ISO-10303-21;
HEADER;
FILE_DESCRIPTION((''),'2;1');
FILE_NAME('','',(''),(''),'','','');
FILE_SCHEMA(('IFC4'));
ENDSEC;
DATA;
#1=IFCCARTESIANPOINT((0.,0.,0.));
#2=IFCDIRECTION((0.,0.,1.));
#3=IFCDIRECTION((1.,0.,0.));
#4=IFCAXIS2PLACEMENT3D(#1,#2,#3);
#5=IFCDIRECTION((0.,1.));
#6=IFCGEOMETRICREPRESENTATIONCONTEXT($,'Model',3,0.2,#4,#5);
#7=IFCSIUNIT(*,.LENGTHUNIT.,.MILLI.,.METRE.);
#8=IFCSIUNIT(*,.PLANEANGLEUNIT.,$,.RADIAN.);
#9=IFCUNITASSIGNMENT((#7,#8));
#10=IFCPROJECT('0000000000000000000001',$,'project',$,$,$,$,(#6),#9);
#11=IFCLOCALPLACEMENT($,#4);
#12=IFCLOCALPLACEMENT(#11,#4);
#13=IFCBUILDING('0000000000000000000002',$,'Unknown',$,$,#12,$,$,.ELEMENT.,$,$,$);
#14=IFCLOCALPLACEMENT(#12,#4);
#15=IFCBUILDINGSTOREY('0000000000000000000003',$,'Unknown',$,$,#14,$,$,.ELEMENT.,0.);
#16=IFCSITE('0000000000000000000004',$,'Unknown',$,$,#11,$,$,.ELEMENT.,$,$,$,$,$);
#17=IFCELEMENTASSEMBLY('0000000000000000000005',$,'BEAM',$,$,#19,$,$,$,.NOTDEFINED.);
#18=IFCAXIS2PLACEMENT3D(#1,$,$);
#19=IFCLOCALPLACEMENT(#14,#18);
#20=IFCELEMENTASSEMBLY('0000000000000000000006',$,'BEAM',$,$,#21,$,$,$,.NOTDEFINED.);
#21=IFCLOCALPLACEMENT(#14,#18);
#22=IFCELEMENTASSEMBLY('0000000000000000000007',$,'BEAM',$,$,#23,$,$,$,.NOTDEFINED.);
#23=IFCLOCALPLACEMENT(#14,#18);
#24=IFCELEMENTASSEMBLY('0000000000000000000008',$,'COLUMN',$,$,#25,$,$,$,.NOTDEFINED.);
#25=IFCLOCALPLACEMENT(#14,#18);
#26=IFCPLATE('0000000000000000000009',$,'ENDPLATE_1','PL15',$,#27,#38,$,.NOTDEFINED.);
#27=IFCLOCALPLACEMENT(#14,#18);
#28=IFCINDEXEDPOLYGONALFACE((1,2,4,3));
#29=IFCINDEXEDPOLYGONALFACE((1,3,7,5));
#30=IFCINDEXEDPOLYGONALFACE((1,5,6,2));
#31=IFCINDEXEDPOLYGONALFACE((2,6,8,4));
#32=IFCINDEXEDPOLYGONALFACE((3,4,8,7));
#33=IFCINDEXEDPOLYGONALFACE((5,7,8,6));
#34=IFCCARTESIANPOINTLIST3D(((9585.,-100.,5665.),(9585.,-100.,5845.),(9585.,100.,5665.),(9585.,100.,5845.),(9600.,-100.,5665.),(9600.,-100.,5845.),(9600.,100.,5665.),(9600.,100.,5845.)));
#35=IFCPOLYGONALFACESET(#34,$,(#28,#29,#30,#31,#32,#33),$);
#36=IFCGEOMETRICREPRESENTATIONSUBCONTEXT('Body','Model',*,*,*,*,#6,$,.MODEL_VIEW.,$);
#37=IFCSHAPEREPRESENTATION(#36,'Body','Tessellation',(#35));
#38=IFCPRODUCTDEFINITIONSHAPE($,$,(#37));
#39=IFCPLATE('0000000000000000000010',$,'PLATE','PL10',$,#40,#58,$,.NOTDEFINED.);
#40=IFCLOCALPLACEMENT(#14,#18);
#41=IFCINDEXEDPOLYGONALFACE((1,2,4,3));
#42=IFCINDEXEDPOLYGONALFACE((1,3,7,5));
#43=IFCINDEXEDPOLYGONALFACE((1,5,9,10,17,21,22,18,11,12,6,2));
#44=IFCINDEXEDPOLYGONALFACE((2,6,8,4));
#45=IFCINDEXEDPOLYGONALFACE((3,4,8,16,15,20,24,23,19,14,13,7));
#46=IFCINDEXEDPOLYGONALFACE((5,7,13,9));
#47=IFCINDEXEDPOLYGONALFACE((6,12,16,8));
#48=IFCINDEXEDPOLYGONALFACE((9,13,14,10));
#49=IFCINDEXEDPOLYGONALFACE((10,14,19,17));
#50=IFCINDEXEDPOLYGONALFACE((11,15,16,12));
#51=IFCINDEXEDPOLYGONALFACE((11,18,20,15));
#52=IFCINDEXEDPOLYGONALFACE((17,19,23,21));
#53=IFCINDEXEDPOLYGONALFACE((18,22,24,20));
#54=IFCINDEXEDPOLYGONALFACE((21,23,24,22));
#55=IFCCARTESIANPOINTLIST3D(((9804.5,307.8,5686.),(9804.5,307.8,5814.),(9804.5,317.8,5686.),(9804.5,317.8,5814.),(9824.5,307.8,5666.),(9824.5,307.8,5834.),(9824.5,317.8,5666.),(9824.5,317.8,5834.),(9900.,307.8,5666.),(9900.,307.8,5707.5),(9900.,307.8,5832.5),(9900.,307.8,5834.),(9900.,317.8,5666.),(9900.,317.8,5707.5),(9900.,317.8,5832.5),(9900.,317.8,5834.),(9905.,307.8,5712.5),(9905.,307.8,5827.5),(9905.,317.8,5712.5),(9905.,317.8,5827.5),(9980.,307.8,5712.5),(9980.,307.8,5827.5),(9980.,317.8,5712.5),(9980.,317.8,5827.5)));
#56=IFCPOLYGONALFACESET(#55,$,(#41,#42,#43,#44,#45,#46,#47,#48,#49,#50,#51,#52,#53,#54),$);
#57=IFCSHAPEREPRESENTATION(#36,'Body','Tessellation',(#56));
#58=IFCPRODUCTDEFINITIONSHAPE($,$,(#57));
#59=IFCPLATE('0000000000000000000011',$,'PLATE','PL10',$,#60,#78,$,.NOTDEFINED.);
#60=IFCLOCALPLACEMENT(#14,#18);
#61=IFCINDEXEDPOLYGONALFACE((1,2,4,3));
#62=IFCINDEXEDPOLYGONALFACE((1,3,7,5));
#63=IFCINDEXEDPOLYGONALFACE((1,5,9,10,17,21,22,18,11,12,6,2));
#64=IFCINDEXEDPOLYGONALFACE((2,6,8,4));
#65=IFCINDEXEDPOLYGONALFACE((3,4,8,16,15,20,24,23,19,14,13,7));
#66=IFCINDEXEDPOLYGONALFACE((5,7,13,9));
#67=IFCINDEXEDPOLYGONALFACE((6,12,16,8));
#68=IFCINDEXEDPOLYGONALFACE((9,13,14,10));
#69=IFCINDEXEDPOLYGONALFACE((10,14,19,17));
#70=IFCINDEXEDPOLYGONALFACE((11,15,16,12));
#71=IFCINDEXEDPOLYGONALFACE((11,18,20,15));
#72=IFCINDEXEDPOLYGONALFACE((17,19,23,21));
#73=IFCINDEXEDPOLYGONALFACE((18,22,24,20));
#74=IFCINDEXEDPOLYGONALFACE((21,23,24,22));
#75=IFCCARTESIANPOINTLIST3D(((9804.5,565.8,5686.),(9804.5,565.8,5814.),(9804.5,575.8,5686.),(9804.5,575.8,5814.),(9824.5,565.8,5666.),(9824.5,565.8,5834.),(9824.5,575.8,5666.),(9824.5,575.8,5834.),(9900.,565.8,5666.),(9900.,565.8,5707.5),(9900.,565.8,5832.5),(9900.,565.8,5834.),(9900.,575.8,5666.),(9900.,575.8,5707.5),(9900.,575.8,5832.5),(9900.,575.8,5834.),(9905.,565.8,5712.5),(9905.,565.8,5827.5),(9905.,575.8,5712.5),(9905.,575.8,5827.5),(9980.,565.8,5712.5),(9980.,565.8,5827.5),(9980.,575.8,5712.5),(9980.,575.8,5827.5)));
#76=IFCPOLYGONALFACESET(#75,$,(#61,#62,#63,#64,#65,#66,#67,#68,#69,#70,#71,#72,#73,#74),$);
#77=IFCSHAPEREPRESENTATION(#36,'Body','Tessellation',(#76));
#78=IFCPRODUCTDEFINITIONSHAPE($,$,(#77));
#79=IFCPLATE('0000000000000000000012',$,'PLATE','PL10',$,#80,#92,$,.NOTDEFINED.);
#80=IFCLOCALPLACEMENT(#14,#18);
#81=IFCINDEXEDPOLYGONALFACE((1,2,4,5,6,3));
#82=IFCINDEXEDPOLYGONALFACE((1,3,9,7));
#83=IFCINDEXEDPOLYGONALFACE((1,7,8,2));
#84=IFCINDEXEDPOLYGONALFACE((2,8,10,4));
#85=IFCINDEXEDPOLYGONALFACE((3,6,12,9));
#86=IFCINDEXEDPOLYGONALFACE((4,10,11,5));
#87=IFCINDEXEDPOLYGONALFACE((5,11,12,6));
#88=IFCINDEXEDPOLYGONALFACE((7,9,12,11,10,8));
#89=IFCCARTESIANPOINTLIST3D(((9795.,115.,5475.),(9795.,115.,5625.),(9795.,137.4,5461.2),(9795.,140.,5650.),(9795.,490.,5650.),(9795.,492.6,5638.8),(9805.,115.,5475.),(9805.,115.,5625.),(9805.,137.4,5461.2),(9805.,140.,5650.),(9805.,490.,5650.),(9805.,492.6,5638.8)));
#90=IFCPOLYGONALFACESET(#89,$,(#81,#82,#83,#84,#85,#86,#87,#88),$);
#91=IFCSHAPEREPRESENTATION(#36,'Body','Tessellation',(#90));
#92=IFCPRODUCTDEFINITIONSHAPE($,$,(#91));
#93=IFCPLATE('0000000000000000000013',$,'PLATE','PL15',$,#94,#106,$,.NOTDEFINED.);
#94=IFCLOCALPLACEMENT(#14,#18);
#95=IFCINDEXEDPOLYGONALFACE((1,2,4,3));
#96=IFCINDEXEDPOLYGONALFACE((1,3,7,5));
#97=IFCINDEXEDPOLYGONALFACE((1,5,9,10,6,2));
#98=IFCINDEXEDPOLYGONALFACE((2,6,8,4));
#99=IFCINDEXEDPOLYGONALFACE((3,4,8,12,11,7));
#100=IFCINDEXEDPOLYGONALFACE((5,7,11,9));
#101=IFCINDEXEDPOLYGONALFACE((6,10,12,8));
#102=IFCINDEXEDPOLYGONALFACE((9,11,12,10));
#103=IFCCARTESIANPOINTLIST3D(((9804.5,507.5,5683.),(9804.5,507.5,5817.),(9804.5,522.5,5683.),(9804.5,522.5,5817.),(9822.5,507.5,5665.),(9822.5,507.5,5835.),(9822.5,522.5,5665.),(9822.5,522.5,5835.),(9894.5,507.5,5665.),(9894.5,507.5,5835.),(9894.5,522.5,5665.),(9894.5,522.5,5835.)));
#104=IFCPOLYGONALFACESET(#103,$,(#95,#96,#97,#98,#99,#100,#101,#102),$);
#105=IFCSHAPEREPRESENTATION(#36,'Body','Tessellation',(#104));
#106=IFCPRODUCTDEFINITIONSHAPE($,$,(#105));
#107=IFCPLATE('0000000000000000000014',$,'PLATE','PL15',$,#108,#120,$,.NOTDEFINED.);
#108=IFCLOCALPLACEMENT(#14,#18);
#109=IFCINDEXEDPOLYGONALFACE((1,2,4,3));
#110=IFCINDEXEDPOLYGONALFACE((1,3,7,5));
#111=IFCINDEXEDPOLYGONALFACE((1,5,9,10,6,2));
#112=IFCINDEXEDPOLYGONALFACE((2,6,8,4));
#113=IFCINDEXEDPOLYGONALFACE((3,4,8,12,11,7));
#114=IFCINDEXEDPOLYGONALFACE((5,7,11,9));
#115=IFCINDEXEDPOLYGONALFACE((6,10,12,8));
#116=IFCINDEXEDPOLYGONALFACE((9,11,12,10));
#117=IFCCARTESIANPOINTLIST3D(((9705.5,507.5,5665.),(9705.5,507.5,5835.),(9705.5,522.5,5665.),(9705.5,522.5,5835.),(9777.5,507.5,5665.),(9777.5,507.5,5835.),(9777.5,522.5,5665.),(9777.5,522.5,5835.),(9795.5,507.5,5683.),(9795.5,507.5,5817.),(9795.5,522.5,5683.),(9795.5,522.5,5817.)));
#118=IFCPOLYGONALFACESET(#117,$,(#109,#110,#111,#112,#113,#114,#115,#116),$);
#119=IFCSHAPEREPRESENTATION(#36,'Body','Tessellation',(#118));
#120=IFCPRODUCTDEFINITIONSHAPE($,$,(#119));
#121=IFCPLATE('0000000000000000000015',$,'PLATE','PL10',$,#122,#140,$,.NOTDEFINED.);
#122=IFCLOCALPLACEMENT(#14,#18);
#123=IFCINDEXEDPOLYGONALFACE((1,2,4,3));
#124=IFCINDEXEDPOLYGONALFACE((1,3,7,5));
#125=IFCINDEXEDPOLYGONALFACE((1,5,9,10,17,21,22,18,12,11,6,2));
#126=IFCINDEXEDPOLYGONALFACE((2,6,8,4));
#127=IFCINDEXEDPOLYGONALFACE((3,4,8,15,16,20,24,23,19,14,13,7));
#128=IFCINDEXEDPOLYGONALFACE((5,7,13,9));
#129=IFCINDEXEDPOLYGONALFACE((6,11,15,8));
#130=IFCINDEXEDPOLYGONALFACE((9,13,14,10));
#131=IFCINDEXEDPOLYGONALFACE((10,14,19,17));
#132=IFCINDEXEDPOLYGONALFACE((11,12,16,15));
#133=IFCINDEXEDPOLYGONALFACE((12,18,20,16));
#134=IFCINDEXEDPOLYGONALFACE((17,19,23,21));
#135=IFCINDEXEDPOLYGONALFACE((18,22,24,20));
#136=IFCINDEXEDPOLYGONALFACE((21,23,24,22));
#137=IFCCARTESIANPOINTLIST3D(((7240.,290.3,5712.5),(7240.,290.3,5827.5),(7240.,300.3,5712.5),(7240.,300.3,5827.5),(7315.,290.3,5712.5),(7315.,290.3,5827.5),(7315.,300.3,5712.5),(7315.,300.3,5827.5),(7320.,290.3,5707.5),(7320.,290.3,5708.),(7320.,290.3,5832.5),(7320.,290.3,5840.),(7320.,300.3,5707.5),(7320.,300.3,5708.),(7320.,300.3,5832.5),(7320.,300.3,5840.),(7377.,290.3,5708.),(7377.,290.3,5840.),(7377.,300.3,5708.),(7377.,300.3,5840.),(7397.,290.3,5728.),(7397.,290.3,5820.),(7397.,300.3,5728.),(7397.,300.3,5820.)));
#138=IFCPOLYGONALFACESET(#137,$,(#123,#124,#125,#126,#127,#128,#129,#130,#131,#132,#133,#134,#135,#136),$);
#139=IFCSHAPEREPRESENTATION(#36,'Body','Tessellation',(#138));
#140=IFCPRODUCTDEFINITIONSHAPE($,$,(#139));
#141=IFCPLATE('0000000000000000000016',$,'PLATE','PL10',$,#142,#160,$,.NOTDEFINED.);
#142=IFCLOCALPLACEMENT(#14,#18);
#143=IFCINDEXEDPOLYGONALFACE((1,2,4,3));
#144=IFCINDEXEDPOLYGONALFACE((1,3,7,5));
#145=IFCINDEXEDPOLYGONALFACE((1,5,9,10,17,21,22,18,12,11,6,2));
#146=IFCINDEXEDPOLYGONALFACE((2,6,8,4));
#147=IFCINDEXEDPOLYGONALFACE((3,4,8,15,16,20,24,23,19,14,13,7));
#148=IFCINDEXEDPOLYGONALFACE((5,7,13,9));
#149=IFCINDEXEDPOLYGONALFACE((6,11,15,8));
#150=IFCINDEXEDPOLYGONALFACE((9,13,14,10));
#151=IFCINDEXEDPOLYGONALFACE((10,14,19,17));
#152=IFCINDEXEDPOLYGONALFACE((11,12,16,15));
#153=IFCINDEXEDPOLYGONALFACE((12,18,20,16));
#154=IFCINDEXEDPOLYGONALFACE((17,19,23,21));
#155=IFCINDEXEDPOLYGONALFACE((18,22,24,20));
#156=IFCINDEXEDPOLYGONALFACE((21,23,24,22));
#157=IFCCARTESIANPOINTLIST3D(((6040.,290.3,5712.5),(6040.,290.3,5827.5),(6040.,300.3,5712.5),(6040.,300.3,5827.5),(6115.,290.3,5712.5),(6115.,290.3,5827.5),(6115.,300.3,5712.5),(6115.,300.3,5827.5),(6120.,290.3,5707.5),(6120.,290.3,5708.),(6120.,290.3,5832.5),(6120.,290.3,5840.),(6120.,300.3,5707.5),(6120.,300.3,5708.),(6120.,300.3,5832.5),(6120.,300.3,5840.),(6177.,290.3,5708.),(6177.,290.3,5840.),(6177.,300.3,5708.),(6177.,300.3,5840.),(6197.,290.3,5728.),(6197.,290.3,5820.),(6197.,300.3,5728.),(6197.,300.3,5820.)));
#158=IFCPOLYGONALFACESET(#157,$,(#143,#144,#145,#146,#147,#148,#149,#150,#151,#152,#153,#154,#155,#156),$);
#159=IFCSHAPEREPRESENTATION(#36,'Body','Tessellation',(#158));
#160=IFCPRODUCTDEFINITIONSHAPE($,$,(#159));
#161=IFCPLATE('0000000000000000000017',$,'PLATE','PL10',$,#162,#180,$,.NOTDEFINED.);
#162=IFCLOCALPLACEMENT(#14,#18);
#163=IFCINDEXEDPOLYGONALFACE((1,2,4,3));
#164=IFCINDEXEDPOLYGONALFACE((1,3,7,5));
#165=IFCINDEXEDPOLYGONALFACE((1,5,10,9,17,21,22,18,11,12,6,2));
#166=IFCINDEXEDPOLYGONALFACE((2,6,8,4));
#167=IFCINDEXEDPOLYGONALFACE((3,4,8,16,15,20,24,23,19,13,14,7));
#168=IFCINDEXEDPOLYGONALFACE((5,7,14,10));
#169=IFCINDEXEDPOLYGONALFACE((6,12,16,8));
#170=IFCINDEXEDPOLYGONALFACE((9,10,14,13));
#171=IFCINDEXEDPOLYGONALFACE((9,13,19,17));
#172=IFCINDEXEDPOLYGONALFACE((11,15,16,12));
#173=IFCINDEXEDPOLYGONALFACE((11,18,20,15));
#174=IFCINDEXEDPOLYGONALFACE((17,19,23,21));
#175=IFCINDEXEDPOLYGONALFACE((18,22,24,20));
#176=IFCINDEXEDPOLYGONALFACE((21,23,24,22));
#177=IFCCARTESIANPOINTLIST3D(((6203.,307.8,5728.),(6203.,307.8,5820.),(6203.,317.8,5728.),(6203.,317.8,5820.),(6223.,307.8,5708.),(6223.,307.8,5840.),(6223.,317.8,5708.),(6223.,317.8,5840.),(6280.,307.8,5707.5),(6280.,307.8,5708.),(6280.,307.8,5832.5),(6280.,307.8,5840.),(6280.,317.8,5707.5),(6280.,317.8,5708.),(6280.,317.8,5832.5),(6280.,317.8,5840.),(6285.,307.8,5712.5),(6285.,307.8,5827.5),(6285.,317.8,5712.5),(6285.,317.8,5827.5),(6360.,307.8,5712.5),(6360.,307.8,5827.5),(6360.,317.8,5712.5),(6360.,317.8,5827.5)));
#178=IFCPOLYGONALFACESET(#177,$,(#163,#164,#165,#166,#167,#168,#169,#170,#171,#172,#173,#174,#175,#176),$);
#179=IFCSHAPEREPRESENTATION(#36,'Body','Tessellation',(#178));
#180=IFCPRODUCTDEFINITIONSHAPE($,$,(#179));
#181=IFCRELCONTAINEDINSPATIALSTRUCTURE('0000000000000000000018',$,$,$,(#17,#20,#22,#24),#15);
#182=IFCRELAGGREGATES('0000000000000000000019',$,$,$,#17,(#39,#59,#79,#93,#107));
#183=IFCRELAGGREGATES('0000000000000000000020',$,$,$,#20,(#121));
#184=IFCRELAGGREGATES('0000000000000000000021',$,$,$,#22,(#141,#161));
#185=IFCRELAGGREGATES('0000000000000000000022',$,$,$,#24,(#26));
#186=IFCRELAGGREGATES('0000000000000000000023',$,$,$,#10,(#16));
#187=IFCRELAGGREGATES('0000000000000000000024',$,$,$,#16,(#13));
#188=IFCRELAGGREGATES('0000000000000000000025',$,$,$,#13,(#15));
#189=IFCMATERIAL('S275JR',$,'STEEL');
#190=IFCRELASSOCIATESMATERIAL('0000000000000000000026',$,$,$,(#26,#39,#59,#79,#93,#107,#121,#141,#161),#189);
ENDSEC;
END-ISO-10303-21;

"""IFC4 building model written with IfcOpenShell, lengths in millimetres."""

from ifc_helpers import new_model, si_unit, direction, frame, origin_with_axes, place, context, subcontext, project, spatial, line, indexed_curve, outline, extrude, material, element, aggregate, save


model = new_model("IFC4")

# Units and contexts
model_context = context("Model", 3, precision=0.2, world=origin_with_axes(), true_north=direction((0.0, 1.0)))
body_context = subcontext(model_context, "Body", "Model", "MODEL_VIEW")
ifc_project = project(units=[si_unit("LENGTHUNIT", "METRE", prefix="MILLI"), si_unit("PLANEANGLEUNIT", "RADIAN")], contexts=[model_context])

# Site, building, storey
site_placement = place(None, origin_with_axes())
site = spatial("IfcSite", under=ifc_project, at=site_placement, Name="Unknown", CompositionType="ELEMENT")
building_placement = place(site_placement, origin_with_axes())
building = spatial("IfcBuilding", under=site, at=building_placement, Name="Unknown", CompositionType="ELEMENT")
storey_placement = place(building_placement, origin_with_axes())
storey = spatial("IfcBuildingStorey", under=building, at=storey_placement, Name="Unknown", CompositionType="ELEMENT", Elevation=0.0)

# Shared definitions
ifc_material_1 = material(Name="S275JR", Category="STEEL")

# Element assemblies
assembly_1_placement = place(storey_placement, frame((9800.0, 0.0, 5750.0), z_axis=(1.0, 0.0, 0.0), x_axis=(0.0, 1.0, 0.0)))
assembly_1 = element("IfcElementAssembly", 1, at=assembly_1_placement, inside=storey, Name="BEAM", PredefinedType="NOTDEFINED")
assembly_2_placement = place(storey_placement, frame((7400.0, 3600.0, 5774.0), z_axis=(-1.0, 0.0, 0.0), x_axis=(-0.000002, -1.0, 0.0)))
assembly_2 = element("IfcElementAssembly", 2, at=assembly_2_placement, inside=storey, Name="BEAM", PredefinedType="NOTDEFINED")
assembly_3_placement = place(storey_placement, frame((6200.0, 3600.0, 5774.0), z_axis=(-1.0, 0.0, 0.0), x_axis=(-0.000002, -1.0, 0.0)))
assembly_3 = element("IfcElementAssembly", 3, at=assembly_3_placement, inside=storey, Name="BEAM", PredefinedType="NOTDEFINED")

# Element assembly, plate
assembly_4_placement = place(storey_placement, frame((9800.0, 0.0, 200.0), z_axis=(-1.0, 0.0, 0.0), x_axis=(0.0, 0.0, 1.0)))
assembly_4 = element("IfcElementAssembly", 4, at=assembly_4_placement, inside=storey, Name="COLUMN", PredefinedType="NOTDEFINED")
plate_1_placement = place(assembly_4_placement, frame((5465.0, -100.0, 207.5), z_axis=(0.0, 0.0, 1.0), x_axis=(1.0, 0.0, 0.0)))
plate_1 = element("IfcPlate", 5, at=plate_1_placement, material=ifc_material_1, Name="ENDPLATE_1", Description="PL15", PredefinedType="NOTDEFINED", context=body_context, shape_type="SolidModel", body=[
    extrude(outline(indexed_curve([(0.0, 0.0), (180.0, 0.0), (180.0, 200.0), (0.0, 200.0)], segments=[line(1, 2, 3, 4, 1)])), frame((0.0, 0.0, 7.5), z_axis=(0.0, 0.0, 1.0), x_axis=(1.0, 0.0, 0.0)), (0.0, -0.000002, -1.0), 15.0),
])

# Plates
plate_2_placement = place(assembly_1_placement, frame((312.8, -64.0, 4.5), z_axis=(-1.0, 0.0, 0.0), x_axis=(0.0, -0.707107, 0.707107)))
plate_2 = element("IfcPlate", 6, at=plate_2_placement, material=ifc_material_1, Name="PLATE", Description="PL10", PredefinedType="NOTDEFINED", context=body_context, shape_type="SolidModel", body=[
    extrude(outline(indexed_curve([(0.0, 0.0), (28.3, 0.0), (81.7, 53.4), (52.3, 82.7), (52.3, 89.8), (105.4, 142.8), (24.0, 224.2), (-29.0, 171.1), (-36.1, 171.1), (-37.1, 172.2), (-90.5, 118.8), (-90.5, 90.5)], segments=[line(1, 2, 3, 4, 5, 6, 7, 8, 9, 10, 11, 12, 1)])), frame((0.0, 0.0, 5.0), z_axis=(0.0, 0.0, 1.0), x_axis=(1.0, 0.0, 0.0)), (0.0, -0.000002, -1.0), 10.0),
])
plate_3_placement = place(assembly_1_placement, frame((570.8, -64.0, 4.5), z_axis=(-1.0, 0.0, 0.0), x_axis=(0.0, -0.707107, 0.707107)))
plate_3 = element("IfcPlate", 7, at=plate_3_placement, material=ifc_material_1, Name="PLATE", Description="PL10", PredefinedType="NOTDEFINED", context=body_context, shape_type="SolidModel", body=[
    extrude(outline(indexed_curve([(0.0, 0.0), (28.3, 0.0), (81.7, 53.4), (52.3, 82.7), (52.3, 89.8), (105.4, 142.8), (24.0, 224.2), (-29.0, 171.1), (-36.1, 171.1), (-37.1, 172.2), (-90.5, 118.8), (-90.5, 90.5)], segments=[line(1, 2, 3, 4, 5, 6, 7, 8, 9, 10, 11, 12, 1)])), frame((0.0, 0.0, 5.0), z_axis=(0.0, 0.0, 1.0), x_axis=(1.0, 0.0, 0.0)), (0.0, -0.000002, -1.0), 10.0),
])
plate_4_placement = place(assembly_1_placement, frame((115.0, -300.0, 0.0), z_axis=(0.0, -0.000002, -1.0), x_axis=(0.0, 1.0, 0.0)))
plate_4 = element("IfcPlate", 8, at=plate_4_placement, material=ifc_material_1, Name="PLATE", Description="PL10", PredefinedType="NOTDEFINED", context=body_context, shape_type="SolidModel", body=[
    extrude(outline(indexed_curve([(11.2, 22.4), (25.0, 0.0), (175.0, 0.0), (200.0, 25.0), (200.0, 375.0), (188.8, 377.6)], segments=[line(1, 2, 3, 4, 5, 6, 1)])), frame((0.0, 0.0, 5.0), z_axis=(0.0, 0.0, 1.0), x_axis=(1.0, 0.0, 0.0)), (0.0, -0.000002, -1.0), 10.0),
])
plate_5_placement = place(assembly_1_placement, frame((515.0, -85.0, 4.5), z_axis=(-1.0, 0.0, 0.0), x_axis=(0.0, 0.0, 1.0)))
plate_5 = element("IfcPlate", 9, at=plate_5_placement, material=ifc_material_1, Name="PLATE", Description="PL15", PredefinedType="NOTDEFINED", context=body_context, shape_type="SolidModel", body=[
    extrude(outline(indexed_curve([(0.0, 18.0), (18.0, 0.0), (90.0, 0.0), (90.0, 170.0), (18.0, 170.0), (0.0, 152.0)], segments=[line(1, 2, 3, 4, 5, 6, 1)])), frame((0.0, 0.0, 7.5), z_axis=(0.0, 0.0, 1.0), x_axis=(1.0, 0.0, 0.0)), (0.0, -0.000002, -1.0), 15.0),
])
plate_6_placement = place(assembly_1_placement, frame((515.0, -85.0, -4.5), z_axis=(1.0, 0.0, 0.0), x_axis=(0.0, -0.000002, -1.0)))
plate_6 = element("IfcPlate", 10, at=plate_6_placement, material=ifc_material_1, Name="PLATE", Description="PL15", PredefinedType="NOTDEFINED", context=body_context, shape_type="SolidModel", body=[
    extrude(outline(indexed_curve([(0.0, 18.0), (18.0, 0.0), (90.0, 0.0), (90.0, 170.0), (18.0, 170.0), (0.0, 152.0)], segments=[line(1, 2, 3, 4, 5, 6, 1)])), frame((0.0, 0.0, 7.5), z_axis=(0.0, 0.0, 1.0), x_axis=(1.0, 0.0, 0.0)), (0.0, -0.000002, -1.0), 15.0),
])
aggregate(assembly_1, [plate_2, plate_3, plate_4, plate_5, plate_6])
plate_7_placement = place(assembly_2_placement, frame((3304.7, -46.0, 3.0), z_axis=(-1.0, 0.0, 0.0), x_axis=(0.0, -0.707107, 0.707107)))
plate_7 = element("IfcPlate", 11, at=plate_7_placement, material=ifc_material_1, Name="PLATE", Description="PL10", PredefinedType="NOTDEFINED", context=body_context, shape_type="SolidModel", body=[
    extrude(outline(indexed_curve([(0.0, 0.0), (28.3, 0.0), (68.6, 40.3), (68.9, 40.0), (68.9, 47.0), (122.0, 100.1), (40.7, 181.4), (-12.4, 128.3), (-19.4, 128.3), (-24.7, 133.6), (-65.1, 93.3), (-65.1, 65.1)], segments=[line(1, 2, 3, 4, 5, 6, 7, 8, 9, 10, 11, 12, 1)])), frame((0.0, 0.0, 5.0), z_axis=(0.0, 0.0, 1.0), x_axis=(1.0, 0.0, 0.0)), (0.0, -0.000002, -1.0), 10.0),
])
aggregate(assembly_2, [plate_7])
plate_8_placement = place(assembly_3_placement, frame((3304.7, -46.0, 3.0), z_axis=(-1.0, 0.0, 0.0), x_axis=(0.0, -0.707107, 0.707107)))
plate_8 = element("IfcPlate", 12, at=plate_8_placement, material=ifc_material_1, Name="PLATE", Description="PL10", PredefinedType="NOTDEFINED", context=body_context, shape_type="SolidModel", body=[
    extrude(outline(indexed_curve([(0.0, 0.0), (28.3, 0.0), (68.6, 40.3), (68.9, 40.0), (68.9, 47.0), (122.0, 100.1), (40.7, 181.4), (-12.4, 128.3), (-19.4, 128.3), (-24.7, 133.6), (-65.1, 93.3), (-65.1, 65.1)], segments=[line(1, 2, 3, 4, 5, 6, 7, 8, 9, 10, 11, 12, 1)])), frame((0.0, 0.0, 5.0), z_axis=(0.0, 0.0, 1.0), x_axis=(1.0, 0.0, 0.0)), (0.0, -0.000002, -1.0), 10.0),
])
plate_9_placement = place(assembly_3_placement, frame((3287.2, -46.0, -3.0), z_axis=(1.0, 0.0, 0.0), x_axis=(0.0, -0.707107, -0.707107)))
plate_9 = element("IfcPlate", 13, at=plate_9_placement, material=ifc_material_1, Name="PLATE", Description="PL10", PredefinedType="NOTDEFINED", context=body_context, shape_type="SolidModel", body=[
    extrude(outline(indexed_curve([(0.0, 0.0), (28.3, 0.0), (68.6, 40.3), (68.9, 40.0), (68.9, 47.0), (122.0, 100.1), (40.7, 181.4), (-12.4, 128.3), (-19.4, 128.3), (-24.7, 133.6), (-65.1, 93.3), (-65.1, 65.1)], segments=[line(1, 2, 3, 4, 5, 6, 7, 8, 9, 10, 11, 12, 1)])), frame((0.0, 0.0, 5.0), z_axis=(0.0, 0.0, 1.0), x_axis=(1.0, 0.0, 0.0)), (0.0, -0.000002, -1.0), 10.0),
])
aggregate(assembly_3, [plate_8, plate_9])

aggregate(assembly_4, [plate_1])

save(model, "model.ifc")
